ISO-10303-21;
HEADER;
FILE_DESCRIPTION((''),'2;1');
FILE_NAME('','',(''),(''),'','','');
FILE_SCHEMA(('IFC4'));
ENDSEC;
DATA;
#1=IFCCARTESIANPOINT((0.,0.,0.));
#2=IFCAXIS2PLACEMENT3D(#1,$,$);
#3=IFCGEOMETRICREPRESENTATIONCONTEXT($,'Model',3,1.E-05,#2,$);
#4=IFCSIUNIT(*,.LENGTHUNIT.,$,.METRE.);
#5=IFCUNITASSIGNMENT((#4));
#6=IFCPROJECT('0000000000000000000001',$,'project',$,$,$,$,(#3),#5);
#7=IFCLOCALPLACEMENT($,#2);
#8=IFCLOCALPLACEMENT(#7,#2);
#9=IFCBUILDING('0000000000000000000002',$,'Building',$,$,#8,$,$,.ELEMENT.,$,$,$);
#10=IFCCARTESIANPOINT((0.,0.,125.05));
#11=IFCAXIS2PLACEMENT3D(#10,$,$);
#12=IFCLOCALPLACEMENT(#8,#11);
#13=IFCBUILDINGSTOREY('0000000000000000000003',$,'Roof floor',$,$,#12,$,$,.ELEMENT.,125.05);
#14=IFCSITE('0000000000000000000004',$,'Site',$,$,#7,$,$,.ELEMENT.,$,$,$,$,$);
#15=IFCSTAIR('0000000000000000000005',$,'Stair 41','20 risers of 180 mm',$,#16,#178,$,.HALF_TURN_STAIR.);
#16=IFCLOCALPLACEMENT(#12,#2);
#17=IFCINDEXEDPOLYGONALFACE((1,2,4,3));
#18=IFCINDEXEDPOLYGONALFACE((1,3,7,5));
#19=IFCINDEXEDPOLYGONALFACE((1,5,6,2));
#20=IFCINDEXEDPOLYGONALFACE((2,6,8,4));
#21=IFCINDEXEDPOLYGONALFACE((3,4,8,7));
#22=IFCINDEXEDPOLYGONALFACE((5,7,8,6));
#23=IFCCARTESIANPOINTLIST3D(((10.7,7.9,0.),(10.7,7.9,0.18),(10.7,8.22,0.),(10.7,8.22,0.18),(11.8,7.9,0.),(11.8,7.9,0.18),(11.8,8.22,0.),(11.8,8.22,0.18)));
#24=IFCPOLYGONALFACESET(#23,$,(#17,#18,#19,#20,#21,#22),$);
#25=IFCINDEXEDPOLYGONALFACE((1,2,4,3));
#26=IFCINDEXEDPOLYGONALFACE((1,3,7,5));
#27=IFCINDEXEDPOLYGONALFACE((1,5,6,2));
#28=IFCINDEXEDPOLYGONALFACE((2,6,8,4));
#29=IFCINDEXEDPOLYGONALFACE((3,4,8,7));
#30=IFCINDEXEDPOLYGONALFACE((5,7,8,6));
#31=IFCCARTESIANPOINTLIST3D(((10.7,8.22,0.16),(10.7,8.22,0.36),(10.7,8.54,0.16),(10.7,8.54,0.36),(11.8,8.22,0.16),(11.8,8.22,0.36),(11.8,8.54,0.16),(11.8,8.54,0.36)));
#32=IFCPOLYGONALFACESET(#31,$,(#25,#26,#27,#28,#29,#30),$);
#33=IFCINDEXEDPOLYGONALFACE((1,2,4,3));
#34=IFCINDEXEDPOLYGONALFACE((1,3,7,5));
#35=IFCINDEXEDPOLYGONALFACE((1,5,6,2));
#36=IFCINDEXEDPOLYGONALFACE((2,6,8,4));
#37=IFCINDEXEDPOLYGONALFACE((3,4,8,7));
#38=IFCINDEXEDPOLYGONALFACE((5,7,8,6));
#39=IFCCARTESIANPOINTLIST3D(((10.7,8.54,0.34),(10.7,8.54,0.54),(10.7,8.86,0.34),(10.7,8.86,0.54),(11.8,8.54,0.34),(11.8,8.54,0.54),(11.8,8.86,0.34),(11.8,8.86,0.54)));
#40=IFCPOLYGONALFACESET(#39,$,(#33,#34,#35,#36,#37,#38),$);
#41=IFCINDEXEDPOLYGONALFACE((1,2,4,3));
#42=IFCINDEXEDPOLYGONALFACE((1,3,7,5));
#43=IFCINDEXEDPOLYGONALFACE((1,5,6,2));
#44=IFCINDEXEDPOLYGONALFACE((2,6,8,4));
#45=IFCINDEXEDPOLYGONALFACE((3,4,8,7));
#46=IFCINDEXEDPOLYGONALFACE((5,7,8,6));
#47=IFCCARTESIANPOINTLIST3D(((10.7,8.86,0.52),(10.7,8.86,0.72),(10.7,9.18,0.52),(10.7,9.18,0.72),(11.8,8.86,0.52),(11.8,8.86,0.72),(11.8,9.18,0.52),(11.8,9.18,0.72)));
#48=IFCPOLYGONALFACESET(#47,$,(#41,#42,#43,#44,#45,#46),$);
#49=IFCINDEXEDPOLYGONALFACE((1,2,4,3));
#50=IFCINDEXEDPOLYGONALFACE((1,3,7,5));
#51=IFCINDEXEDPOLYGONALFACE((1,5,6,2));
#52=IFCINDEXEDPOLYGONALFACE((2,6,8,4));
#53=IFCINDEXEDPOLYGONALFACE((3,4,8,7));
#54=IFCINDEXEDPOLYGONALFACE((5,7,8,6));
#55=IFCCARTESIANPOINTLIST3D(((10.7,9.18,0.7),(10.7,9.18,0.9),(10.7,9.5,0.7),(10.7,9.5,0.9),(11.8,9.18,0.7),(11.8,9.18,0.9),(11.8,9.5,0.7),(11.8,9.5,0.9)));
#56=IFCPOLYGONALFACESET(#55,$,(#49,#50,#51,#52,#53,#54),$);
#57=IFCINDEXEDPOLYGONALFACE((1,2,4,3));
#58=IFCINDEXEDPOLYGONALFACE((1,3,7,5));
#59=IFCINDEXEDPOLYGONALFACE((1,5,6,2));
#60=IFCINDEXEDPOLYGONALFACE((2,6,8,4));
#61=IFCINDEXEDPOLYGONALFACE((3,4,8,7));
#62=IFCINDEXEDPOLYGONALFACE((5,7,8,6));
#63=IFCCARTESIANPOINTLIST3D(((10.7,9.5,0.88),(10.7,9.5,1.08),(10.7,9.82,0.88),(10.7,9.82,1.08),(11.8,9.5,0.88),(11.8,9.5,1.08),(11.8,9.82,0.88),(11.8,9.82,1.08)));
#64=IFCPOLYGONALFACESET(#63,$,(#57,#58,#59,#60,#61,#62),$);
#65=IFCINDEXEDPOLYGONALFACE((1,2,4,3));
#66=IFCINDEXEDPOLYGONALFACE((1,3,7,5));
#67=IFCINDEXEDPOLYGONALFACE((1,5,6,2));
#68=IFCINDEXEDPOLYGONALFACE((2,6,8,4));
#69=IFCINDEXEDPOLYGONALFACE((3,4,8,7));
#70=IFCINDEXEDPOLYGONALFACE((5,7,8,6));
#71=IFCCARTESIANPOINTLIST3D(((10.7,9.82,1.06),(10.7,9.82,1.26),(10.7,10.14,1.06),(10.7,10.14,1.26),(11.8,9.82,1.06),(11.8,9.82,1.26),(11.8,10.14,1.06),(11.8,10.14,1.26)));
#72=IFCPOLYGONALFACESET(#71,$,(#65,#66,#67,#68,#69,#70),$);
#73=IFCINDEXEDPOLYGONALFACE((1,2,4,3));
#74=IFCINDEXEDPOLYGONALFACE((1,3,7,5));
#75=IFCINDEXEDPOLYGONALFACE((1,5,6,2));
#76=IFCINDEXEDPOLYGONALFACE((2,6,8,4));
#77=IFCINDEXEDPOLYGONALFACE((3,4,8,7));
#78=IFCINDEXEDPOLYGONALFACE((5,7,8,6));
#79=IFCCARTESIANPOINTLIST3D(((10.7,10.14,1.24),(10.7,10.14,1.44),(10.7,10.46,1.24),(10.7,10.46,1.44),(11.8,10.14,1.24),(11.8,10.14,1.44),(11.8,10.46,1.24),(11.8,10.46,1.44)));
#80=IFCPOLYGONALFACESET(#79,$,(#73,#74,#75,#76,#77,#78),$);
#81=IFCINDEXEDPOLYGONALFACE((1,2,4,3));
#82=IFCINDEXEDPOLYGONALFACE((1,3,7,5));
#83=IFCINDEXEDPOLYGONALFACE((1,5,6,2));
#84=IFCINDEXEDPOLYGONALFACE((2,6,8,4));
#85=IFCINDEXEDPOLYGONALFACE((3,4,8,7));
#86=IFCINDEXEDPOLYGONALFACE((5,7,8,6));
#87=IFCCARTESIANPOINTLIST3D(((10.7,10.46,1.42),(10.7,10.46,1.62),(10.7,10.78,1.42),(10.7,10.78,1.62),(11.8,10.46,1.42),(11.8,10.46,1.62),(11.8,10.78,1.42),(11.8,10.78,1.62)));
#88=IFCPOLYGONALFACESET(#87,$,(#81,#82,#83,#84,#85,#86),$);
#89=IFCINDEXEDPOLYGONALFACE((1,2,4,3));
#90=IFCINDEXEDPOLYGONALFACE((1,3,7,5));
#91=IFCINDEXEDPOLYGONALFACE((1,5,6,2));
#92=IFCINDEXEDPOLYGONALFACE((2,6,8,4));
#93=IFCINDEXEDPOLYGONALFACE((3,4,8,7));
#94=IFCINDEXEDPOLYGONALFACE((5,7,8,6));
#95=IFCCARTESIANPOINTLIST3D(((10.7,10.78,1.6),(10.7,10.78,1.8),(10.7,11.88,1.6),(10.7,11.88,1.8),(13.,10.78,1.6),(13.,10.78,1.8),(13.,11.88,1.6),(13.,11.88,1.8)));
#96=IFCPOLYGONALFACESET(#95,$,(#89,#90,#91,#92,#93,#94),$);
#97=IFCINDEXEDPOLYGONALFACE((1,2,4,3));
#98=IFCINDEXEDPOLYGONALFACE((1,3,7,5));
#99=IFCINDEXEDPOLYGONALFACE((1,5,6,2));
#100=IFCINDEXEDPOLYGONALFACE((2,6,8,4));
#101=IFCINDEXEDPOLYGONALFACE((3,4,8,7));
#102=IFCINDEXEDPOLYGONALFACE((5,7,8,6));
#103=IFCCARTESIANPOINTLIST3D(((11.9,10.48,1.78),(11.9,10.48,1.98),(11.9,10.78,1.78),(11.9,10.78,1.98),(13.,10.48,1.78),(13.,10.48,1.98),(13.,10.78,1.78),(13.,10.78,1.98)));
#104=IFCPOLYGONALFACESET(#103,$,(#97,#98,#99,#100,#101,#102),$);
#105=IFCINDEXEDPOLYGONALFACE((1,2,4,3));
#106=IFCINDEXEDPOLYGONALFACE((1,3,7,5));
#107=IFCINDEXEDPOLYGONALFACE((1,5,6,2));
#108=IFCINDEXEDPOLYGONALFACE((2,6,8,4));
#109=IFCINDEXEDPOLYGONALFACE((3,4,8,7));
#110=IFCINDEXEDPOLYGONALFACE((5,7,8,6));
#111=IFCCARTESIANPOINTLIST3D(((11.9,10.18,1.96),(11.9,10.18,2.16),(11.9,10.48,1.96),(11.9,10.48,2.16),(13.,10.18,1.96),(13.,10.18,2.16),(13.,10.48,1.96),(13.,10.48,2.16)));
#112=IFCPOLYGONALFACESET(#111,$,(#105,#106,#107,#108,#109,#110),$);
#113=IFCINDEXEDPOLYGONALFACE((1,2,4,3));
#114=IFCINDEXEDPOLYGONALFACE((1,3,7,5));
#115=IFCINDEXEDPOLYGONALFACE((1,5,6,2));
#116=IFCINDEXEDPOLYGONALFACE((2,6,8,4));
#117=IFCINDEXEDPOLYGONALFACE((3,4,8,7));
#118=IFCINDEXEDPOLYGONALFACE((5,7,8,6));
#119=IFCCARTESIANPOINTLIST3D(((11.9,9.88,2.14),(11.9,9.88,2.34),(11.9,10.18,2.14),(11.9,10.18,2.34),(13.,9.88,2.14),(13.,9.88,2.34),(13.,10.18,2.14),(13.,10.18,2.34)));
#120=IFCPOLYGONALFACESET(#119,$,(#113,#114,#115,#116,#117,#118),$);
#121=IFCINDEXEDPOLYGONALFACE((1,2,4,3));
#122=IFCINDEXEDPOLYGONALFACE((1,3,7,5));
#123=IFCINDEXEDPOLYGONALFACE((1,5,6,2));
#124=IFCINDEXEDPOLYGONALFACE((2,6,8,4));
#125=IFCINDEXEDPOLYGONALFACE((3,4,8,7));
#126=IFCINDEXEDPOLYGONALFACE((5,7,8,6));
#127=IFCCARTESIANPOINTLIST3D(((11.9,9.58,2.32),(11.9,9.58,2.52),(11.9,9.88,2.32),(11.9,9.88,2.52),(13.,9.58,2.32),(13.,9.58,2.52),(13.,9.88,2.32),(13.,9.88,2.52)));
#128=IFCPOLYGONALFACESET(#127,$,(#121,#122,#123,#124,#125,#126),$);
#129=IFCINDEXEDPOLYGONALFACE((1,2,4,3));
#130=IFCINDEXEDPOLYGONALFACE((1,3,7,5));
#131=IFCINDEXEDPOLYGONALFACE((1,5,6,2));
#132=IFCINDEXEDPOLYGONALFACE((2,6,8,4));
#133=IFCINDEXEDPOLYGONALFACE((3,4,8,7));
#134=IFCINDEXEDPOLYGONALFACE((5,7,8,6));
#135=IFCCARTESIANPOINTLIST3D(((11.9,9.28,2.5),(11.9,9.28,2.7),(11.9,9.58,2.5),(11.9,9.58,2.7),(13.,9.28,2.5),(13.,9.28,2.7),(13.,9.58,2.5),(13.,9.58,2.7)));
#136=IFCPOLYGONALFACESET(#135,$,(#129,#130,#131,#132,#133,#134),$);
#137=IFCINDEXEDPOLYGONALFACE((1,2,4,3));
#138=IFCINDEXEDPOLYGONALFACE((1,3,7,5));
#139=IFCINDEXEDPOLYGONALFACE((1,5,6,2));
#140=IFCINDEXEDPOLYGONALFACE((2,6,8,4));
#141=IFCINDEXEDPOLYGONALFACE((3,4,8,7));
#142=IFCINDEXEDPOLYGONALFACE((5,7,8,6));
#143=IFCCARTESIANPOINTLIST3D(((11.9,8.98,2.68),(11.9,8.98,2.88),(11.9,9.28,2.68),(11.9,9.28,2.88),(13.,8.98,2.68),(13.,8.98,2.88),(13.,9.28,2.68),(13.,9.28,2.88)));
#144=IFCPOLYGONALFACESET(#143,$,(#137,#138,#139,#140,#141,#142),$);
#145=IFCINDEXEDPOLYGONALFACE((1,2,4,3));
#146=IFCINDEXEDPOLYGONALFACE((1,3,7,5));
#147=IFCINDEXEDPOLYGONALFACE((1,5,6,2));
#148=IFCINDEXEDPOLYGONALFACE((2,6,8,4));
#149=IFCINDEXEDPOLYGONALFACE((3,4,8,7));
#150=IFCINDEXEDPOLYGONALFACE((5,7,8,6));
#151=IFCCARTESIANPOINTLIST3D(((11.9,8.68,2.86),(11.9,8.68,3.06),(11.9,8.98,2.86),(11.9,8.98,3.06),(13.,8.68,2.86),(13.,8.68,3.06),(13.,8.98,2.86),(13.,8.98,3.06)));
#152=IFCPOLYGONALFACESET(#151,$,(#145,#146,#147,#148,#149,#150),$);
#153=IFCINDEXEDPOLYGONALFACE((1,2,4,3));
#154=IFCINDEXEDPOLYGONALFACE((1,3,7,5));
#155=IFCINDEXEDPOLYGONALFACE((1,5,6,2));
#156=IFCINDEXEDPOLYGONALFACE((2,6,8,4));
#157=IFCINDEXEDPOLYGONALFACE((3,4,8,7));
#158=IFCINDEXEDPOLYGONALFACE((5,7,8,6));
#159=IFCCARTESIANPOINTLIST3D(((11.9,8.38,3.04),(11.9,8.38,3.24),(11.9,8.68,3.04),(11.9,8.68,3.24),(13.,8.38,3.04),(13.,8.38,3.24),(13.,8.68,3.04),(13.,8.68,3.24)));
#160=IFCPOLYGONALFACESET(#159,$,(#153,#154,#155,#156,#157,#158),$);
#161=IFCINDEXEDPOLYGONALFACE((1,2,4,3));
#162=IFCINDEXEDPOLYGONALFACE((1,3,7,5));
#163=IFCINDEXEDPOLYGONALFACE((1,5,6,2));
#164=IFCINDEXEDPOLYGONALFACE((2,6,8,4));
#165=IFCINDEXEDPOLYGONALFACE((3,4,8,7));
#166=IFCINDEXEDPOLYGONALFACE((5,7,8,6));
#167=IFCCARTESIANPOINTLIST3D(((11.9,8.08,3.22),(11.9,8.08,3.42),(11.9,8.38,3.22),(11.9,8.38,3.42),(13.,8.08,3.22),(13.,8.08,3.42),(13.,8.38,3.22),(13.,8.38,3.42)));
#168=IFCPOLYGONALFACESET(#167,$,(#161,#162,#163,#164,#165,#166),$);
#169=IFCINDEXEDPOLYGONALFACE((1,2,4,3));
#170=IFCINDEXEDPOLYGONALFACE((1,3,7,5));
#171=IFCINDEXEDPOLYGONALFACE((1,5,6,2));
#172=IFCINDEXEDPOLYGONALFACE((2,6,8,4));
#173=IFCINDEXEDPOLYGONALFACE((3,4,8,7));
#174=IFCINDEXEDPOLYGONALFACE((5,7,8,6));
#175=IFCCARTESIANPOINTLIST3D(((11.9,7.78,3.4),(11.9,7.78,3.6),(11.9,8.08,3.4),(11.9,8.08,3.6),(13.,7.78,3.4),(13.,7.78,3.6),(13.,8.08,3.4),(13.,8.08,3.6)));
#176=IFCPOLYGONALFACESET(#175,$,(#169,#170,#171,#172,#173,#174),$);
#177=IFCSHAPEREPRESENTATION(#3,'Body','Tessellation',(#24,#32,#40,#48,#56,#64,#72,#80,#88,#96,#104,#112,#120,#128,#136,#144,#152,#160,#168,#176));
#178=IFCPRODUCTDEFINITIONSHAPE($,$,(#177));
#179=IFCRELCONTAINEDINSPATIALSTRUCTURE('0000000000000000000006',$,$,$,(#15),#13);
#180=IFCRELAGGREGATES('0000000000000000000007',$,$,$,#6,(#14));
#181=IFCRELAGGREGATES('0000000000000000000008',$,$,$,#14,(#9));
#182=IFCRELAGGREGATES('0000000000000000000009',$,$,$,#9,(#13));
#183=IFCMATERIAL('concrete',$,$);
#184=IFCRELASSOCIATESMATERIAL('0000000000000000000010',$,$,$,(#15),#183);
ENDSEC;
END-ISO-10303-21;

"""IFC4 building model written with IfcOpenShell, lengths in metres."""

from ifc_helpers import new_model, si_unit, frame, origin, place, context, project, spatial, polyline, outline, extrude, material, element, save


model = new_model("IFC4")

# Units and contexts
model_context = context("Model", 3, precision=1e-05, world=origin())
ifc_project = project(units=[si_unit("LENGTHUNIT", "METRE")], contexts=[model_context])

# Site, building, storey
site_placement = place(None, origin())
site = spatial("IfcSite", under=ifc_project, at=site_placement, Name="Site", CompositionType="ELEMENT")
building_placement = place(site_placement, origin())
building = spatial("IfcBuilding", under=site, at=building_placement, Name="Building", CompositionType="ELEMENT")
storey_placement = place(building_placement, frame((0.0, 0.0, 125.05)))
storey = spatial("IfcBuildingStorey", under=building, at=storey_placement, Name="Roof floor", CompositionType="ELEMENT", Elevation=125.05)

# Shared definitions
ifc_material = material(Name="concrete")

# Stair
stair_placement = place(storey_placement, frame((11.25, 7.9, 0.0), z_axis=(0.0, 0.0, 1.0), x_axis=(0.0, 1.0, 0.0)))
element("IfcStair", 1, at=stair_placement, inside=storey, material=ifc_material, Name="Stair 41", Description="20 risers of 180 mm", PredefinedType="HALF_TURN_STAIR", context=model_context, shape_type="SweptSolid", body=[
    extrude(outline(polyline([(0.0, -0.55), (0.32, -0.55), (0.32, 0.55), (0.0, 0.55), (0.0, -0.55)])), origin(), (0.0, 0.0, 1.0), 0.18),
    extrude(outline(polyline([(0.32, -0.55), (0.64, -0.55), (0.64, 0.55), (0.32, 0.55), (0.32, -0.55)])), frame((0.0, 0.0, 0.16)), (0.0, 0.0, 1.0), 0.2),
    extrude(outline(polyline([(0.64, -0.55), (0.96, -0.55), (0.96, 0.55), (0.64, 0.55), (0.64, -0.55)])), frame((0.0, 0.0, 0.34)), (0.0, 0.0, 1.0), 0.2),
    extrude(outline(polyline([(0.96, -0.55), (1.28, -0.55), (1.28, 0.55), (0.96, 0.55), (0.96, -0.55)])), frame((0.0, 0.0, 0.52)), (0.0, 0.0, 1.0), 0.2),
    extrude(outline(polyline([(1.28, -0.55), (1.6, -0.55), (1.6, 0.55), (1.28, 0.55), (1.28, -0.55)])), frame((0.0, 0.0, 0.7)), (0.0, 0.0, 1.0), 0.2),
    extrude(outline(polyline([(1.6, -0.55), (1.92, -0.55), (1.92, 0.55), (1.6, 0.55), (1.6, -0.55)])), frame((0.0, 0.0, 0.88)), (0.0, 0.0, 1.0), 0.2),
    extrude(outline(polyline([(1.92, -0.55), (2.24, -0.55), (2.24, 0.55), (1.92, 0.55), (1.92, -0.55)])), frame((0.0, 0.0, 1.06)), (0.0, 0.0, 1.0), 0.2),
    extrude(outline(polyline([(2.24, -0.55), (2.56, -0.55), (2.56, 0.55), (2.24, 0.55), (2.24, -0.55)])), frame((0.0, 0.0, 1.24)), (0.0, 0.0, 1.0), 0.2),
    extrude(outline(polyline([(2.56, -0.55), (2.88, -0.55), (2.88, 0.55), (2.56, 0.55), (2.56, -0.55)])), frame((0.0, 0.0, 1.42)), (0.0, 0.0, 1.0), 0.2),
    extrude(outline(polyline([(2.88, -1.75), (3.98, -1.75), (3.98, 0.55), (2.88, 0.55), (2.88, -1.75)])), frame((0.0, 0.0, 1.6)), (0.0, 0.0, 1.0), 0.2),
    extrude(outline(polyline([(2.58, -1.75), (2.88, -1.75), (2.88, -0.65), (2.58, -0.65), (2.58, -1.75)])), frame((0.0, 0.0, 1.78)), (0.0, 0.0, 1.0), 0.2),
    extrude(outline(polyline([(2.28, -1.75), (2.58, -1.75), (2.58, -0.65), (2.28, -0.65), (2.28, -1.75)])), frame((0.0, 0.0, 1.96)), (0.0, 0.0, 1.0), 0.2),
    extrude(outline(polyline([(1.98, -1.75), (2.28, -1.75), (2.28, -0.65), (1.98, -0.65), (1.98, -1.75)])), frame((0.0, 0.0, 2.14)), (0.0, 0.0, 1.0), 0.2),
    extrude(outline(polyline([(1.68, -1.75), (1.98, -1.75), (1.98, -0.65), (1.68, -0.65), (1.68, -1.75)])), frame((0.0, 0.0, 2.32)), (0.0, 0.0, 1.0), 0.2),
    extrude(outline(polyline([(1.38, -1.75), (1.68, -1.75), (1.68, -0.65), (1.38, -0.65), (1.38, -1.75)])), frame((0.0, 0.0, 2.5)), (0.0, 0.0, 1.0), 0.2),
    extrude(outline(polyline([(1.08, -1.75), (1.38, -1.75), (1.38, -0.65), (1.08, -0.65), (1.08, -1.75)])), frame((0.0, 0.0, 2.68)), (0.0, 0.0, 1.0), 0.2),
    extrude(outline(polyline([(0.78, -1.75), (1.08, -1.75), (1.08, -0.65), (0.78, -0.65), (0.78, -1.75)])), frame((0.0, 0.0, 2.86)), (0.0, 0.0, 1.0), 0.2),
    extrude(outline(polyline([(0.48, -1.75), (0.78, -1.75), (0.78, -0.65), (0.48, -0.65), (0.48, -1.75)])), frame((0.0, 0.0, 3.04)), (0.0, 0.0, 1.0), 0.2),
    extrude(outline(polyline([(0.18, -1.75), (0.48, -1.75), (0.48, -0.65), (0.18, -0.65), (0.18, -1.75)])), frame((0.0, 0.0, 3.22)), (0.0, 0.0, 1.0), 0.2),
    extrude(outline(polyline([(-0.12, -1.75), (0.18, -1.75), (0.18, -0.65), (-0.12, -0.65), (-0.12, -1.75)])), frame((0.0, 0.0, 3.4)), (0.0, 0.0, 1.0), 0.2),
])

save(model, "model.ifc")
